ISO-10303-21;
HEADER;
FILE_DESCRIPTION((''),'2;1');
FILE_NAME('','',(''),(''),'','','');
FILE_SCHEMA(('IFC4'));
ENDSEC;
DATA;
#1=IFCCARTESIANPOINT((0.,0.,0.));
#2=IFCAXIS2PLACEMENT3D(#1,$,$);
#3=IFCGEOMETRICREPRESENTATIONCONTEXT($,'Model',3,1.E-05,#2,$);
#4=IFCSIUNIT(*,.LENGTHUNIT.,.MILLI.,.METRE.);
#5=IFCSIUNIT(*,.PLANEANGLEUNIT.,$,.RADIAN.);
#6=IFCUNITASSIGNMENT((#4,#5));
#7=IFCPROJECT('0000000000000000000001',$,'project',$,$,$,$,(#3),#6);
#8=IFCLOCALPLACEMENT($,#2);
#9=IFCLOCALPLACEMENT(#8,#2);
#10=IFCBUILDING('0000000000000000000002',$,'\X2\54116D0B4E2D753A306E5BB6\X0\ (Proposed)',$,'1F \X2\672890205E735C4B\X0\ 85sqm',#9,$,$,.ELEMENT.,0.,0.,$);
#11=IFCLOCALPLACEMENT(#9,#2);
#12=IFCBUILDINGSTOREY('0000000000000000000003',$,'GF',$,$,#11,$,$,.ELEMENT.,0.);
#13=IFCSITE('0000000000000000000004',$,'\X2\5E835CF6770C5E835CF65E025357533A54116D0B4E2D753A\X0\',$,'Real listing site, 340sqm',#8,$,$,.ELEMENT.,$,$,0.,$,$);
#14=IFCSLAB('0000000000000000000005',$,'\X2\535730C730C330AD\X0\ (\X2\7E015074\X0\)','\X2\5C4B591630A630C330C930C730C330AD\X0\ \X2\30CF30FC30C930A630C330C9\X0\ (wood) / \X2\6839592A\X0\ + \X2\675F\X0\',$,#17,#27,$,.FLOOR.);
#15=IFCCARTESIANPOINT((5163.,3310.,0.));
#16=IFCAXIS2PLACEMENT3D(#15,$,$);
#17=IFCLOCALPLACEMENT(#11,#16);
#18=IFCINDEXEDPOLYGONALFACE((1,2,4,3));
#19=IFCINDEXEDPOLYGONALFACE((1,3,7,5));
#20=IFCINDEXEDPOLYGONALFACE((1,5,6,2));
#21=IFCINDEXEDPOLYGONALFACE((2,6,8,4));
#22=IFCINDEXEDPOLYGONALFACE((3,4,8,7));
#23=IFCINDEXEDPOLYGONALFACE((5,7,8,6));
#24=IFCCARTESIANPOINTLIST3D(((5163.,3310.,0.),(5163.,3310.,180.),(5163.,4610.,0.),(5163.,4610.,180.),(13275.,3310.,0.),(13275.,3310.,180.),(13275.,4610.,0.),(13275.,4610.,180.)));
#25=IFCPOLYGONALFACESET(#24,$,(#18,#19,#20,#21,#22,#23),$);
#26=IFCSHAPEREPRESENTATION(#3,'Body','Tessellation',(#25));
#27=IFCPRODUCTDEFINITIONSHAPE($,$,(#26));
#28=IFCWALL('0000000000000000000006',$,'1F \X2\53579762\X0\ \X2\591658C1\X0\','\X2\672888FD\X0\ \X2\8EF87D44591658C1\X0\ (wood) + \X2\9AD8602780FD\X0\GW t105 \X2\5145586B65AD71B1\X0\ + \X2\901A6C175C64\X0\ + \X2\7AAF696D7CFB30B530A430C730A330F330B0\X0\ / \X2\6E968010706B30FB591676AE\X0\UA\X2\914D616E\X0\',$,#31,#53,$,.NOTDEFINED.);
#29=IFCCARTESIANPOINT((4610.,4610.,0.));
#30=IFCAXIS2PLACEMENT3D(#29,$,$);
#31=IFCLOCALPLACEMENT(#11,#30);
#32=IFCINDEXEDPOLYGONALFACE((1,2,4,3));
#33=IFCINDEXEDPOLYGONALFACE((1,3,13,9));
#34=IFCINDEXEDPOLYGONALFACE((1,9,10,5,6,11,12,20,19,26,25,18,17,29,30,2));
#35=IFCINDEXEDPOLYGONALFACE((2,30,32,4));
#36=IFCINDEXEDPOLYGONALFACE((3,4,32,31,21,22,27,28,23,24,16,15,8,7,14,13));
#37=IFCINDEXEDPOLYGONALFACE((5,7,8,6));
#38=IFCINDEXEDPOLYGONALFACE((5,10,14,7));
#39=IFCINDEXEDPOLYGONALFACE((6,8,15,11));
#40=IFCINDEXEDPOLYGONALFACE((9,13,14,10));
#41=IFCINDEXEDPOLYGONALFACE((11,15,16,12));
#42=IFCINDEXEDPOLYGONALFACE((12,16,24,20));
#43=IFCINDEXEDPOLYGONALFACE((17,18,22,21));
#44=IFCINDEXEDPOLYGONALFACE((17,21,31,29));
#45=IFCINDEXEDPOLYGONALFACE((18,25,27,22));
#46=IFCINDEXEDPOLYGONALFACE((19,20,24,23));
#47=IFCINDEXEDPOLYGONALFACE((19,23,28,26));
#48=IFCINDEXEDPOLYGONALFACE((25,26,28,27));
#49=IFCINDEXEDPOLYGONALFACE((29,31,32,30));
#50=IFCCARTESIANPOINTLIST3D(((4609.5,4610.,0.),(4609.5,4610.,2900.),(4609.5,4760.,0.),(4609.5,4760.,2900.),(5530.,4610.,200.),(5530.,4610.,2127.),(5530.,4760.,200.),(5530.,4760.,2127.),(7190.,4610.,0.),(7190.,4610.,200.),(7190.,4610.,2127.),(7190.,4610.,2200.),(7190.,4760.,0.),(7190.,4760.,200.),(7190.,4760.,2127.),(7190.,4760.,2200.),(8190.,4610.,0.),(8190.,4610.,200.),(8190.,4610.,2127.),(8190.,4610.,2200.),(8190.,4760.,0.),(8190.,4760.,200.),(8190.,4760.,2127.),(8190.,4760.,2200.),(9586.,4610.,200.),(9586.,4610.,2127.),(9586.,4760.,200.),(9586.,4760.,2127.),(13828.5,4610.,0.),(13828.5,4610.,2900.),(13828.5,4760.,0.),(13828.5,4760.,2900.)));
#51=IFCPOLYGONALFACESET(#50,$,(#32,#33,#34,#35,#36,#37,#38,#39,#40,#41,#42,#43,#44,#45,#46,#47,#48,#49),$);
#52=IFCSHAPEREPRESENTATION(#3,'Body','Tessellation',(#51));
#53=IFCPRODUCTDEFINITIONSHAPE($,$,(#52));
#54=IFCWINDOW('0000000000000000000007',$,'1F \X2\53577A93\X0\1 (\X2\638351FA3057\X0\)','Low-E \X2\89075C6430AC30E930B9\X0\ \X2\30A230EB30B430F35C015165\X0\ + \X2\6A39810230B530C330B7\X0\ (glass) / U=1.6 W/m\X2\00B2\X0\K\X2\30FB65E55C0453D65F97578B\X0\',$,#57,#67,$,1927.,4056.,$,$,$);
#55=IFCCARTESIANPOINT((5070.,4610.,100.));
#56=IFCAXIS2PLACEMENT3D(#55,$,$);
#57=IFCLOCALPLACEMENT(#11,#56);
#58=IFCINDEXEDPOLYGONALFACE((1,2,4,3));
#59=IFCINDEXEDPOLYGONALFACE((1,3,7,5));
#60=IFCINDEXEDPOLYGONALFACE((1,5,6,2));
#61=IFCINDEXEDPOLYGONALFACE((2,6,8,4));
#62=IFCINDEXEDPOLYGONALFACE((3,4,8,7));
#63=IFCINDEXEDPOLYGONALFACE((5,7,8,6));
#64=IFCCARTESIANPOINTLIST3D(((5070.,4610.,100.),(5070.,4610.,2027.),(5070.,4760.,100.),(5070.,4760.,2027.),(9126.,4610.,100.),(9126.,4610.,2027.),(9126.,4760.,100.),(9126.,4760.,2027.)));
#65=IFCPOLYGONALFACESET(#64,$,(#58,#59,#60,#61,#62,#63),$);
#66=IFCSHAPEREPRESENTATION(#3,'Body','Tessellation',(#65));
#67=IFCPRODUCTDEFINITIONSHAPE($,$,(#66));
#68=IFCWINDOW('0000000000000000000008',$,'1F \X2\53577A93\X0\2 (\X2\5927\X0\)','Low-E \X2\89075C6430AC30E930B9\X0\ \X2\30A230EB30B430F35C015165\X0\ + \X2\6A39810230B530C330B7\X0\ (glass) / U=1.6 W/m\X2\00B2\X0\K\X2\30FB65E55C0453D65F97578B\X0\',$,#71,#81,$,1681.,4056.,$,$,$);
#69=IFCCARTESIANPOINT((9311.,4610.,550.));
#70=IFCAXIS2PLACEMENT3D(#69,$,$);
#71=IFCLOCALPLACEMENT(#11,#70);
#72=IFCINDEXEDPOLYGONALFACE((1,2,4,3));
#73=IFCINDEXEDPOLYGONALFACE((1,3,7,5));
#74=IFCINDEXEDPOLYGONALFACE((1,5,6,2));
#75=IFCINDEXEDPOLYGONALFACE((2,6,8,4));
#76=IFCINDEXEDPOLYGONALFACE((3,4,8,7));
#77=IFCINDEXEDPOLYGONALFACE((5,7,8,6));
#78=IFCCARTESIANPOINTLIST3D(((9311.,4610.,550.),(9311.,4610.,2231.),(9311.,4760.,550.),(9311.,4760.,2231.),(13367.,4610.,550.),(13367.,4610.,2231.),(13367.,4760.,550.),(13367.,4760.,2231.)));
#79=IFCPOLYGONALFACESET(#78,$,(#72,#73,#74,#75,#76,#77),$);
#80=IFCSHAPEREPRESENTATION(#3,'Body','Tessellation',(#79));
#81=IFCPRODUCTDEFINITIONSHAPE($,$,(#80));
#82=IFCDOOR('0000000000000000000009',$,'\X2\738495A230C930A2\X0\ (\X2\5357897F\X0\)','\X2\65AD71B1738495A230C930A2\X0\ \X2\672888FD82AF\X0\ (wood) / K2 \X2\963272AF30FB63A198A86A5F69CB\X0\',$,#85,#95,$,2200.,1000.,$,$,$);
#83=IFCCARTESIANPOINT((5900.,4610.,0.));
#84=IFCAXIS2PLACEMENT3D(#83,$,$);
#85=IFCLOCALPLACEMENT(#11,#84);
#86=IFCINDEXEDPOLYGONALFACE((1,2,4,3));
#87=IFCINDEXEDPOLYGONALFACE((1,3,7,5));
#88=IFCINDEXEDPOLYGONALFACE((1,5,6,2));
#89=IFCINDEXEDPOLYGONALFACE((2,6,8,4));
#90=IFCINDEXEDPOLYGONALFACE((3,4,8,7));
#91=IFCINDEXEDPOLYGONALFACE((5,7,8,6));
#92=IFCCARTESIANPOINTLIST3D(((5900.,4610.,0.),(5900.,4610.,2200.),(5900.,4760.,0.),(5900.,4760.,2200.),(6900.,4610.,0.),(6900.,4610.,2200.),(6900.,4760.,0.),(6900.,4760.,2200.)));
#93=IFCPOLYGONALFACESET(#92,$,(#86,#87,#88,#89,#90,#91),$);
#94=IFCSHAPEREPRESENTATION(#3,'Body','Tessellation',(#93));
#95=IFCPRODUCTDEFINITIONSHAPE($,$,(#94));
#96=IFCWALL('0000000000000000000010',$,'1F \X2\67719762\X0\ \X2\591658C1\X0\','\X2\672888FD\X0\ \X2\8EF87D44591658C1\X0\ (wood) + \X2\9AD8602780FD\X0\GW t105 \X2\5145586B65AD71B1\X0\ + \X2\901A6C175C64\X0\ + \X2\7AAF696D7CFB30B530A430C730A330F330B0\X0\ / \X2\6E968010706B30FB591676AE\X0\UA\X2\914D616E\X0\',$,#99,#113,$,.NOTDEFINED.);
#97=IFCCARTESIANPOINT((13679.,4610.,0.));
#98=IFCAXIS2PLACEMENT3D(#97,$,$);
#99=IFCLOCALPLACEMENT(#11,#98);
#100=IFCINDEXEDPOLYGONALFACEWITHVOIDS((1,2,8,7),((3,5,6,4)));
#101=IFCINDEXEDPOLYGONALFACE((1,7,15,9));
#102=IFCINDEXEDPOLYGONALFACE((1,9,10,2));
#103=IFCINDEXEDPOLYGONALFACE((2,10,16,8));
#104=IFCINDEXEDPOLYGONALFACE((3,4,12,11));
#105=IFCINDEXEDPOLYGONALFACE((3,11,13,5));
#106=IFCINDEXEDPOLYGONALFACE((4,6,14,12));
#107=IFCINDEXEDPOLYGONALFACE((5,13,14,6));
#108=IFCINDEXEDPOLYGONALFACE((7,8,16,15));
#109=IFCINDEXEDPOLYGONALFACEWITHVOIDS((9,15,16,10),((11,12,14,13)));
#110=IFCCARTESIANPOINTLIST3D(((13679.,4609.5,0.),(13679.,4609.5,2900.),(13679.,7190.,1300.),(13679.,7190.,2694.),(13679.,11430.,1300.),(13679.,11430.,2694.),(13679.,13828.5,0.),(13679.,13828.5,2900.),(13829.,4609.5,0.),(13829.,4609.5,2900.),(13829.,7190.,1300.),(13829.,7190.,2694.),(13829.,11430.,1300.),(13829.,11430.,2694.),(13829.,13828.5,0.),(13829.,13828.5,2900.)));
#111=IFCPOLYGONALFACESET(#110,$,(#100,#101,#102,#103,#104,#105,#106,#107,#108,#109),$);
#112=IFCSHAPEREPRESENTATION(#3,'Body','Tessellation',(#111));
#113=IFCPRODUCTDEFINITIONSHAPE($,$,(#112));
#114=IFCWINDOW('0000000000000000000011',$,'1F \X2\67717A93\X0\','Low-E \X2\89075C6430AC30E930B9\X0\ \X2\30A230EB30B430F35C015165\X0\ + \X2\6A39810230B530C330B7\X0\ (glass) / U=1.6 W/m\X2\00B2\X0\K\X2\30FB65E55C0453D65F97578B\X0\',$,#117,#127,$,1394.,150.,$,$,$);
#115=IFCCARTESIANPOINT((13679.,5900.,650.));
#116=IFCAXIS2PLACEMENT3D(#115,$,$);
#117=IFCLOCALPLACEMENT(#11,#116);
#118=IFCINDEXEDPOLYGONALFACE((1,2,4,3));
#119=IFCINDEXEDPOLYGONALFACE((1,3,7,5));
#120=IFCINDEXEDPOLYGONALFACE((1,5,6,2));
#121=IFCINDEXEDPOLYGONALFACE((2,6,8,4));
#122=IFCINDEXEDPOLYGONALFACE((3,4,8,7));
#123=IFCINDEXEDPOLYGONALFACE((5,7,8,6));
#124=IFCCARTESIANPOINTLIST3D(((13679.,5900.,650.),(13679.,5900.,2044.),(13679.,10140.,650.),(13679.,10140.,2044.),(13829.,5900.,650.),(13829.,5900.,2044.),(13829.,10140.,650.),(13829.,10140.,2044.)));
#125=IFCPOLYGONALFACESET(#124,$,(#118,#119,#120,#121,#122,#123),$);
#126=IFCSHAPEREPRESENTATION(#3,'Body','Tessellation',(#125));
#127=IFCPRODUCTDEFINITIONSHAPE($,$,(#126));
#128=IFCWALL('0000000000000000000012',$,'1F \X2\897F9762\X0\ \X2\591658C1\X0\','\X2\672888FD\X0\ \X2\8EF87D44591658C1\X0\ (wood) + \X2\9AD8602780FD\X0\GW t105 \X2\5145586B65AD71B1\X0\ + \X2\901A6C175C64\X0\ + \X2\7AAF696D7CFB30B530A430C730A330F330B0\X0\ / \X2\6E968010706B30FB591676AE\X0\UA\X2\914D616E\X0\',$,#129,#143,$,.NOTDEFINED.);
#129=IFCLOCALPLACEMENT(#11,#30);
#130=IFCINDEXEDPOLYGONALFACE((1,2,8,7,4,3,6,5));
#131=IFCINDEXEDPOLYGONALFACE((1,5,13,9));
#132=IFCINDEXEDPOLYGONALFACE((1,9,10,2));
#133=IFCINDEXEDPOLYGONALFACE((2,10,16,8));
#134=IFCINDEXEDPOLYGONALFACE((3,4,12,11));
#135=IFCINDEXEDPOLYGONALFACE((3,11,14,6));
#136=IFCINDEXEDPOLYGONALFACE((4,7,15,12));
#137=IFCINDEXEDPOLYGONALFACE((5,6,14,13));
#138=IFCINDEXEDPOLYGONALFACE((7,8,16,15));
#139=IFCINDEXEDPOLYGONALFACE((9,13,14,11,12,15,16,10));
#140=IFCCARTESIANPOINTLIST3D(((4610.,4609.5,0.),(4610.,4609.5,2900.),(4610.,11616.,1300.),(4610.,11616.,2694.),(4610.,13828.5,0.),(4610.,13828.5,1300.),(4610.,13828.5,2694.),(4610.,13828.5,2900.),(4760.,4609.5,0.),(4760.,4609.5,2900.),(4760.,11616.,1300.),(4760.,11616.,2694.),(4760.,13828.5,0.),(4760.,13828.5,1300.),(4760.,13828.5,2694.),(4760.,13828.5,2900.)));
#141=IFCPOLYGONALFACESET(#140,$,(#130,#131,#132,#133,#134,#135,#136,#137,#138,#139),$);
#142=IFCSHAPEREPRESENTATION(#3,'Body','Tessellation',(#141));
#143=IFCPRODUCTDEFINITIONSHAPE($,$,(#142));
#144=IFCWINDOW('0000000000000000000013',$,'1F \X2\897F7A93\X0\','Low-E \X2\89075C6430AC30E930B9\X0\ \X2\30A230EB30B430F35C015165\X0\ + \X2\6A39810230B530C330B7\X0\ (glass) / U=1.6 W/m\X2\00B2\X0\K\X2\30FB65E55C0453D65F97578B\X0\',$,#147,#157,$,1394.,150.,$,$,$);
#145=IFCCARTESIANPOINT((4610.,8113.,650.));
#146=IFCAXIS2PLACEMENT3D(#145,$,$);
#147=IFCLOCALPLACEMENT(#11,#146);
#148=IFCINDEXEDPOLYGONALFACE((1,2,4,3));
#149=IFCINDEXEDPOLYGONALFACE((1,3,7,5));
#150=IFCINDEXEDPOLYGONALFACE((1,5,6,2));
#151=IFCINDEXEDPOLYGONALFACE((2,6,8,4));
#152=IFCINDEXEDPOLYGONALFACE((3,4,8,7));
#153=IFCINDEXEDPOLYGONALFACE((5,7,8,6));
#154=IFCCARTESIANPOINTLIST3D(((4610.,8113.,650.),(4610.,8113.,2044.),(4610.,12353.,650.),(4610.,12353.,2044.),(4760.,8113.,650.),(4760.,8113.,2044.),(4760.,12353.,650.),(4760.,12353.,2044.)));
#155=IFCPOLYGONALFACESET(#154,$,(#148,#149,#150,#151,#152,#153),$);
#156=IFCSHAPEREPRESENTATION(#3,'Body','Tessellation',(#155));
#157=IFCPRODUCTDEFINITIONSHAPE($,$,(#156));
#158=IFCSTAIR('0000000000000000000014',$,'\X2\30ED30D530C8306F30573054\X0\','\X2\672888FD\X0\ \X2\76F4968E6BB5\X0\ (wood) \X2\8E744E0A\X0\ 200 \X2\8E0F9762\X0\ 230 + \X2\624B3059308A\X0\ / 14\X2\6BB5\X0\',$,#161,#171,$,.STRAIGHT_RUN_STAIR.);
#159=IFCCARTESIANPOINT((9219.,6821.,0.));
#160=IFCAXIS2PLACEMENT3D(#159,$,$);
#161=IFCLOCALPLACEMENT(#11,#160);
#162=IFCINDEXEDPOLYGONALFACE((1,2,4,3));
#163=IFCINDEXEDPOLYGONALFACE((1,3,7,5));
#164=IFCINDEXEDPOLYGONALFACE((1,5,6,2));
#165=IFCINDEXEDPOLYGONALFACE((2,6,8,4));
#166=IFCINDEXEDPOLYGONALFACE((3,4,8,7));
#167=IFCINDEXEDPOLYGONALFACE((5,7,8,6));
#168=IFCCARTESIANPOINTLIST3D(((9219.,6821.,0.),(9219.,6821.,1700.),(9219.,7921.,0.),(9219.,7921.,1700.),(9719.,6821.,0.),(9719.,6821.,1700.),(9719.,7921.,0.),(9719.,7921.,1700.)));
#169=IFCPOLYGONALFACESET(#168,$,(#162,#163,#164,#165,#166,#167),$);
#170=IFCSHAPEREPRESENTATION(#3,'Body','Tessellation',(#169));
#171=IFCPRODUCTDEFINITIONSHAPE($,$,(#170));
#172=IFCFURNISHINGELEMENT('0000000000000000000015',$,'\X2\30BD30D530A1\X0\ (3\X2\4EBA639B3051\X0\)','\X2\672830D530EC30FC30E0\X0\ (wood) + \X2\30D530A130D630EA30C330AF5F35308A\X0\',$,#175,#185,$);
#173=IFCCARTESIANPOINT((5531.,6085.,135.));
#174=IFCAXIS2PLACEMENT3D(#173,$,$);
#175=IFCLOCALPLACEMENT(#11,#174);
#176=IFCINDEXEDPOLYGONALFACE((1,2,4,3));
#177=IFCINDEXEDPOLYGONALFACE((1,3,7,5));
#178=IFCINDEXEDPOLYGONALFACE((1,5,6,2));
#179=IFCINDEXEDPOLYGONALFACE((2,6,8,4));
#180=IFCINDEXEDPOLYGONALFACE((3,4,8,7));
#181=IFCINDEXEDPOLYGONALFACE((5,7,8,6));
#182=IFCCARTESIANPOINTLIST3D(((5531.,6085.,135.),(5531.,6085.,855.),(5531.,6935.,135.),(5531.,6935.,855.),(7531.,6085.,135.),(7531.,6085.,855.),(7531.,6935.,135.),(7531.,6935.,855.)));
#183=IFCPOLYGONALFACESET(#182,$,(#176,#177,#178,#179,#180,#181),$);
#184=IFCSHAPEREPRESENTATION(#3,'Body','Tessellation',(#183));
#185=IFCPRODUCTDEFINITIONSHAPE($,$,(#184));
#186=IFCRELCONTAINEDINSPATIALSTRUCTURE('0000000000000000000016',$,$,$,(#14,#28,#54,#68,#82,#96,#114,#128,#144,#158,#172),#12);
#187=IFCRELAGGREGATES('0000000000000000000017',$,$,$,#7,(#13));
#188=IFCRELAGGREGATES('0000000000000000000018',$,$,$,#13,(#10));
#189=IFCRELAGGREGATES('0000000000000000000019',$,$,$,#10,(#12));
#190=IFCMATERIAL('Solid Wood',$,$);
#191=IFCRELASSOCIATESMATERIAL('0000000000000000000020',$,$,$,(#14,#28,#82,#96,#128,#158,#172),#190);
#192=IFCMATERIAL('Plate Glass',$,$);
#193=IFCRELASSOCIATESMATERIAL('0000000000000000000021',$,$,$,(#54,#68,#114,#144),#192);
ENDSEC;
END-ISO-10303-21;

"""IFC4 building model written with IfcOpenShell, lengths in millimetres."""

from ifc_helpers import new_model, si_unit, frame, frame_2d, origin, place, context, project, spatial, rectangle, extrude, material, element, fill, save


model = new_model("IFC4")

# Units and contexts
model_context = context("Model", 3, precision=1e-05, world=origin())
ifc_project = project(units=[si_unit("LENGTHUNIT", "METRE", prefix="MILLI"), si_unit("PLANEANGLEUNIT", "RADIAN")], contexts=[model_context])

# Site, building, storey
site_placement = place(None, origin())
site = spatial("IfcSite", under=ifc_project, at=site_placement, Name="広島県広島市南区向洋中町", ObjectType="Real listing site, 340sqm", CompositionType="ELEMENT", RefElevation=0.0)
building_placement = place(site_placement, origin())
building = spatial("IfcBuilding", under=site, at=building_placement, Name="向洋中町の家 (Proposed)", ObjectType="1F 木造平屋 85sqm", CompositionType="ELEMENT", ElevationOfRefHeight=0.0, ElevationOfTerrain=0.0)
storey_placement = place(building_placement, origin())
storey = spatial("IfcBuildingStorey", under=building, at=storey_placement, Name="GF", CompositionType="ELEMENT", Elevation=0.0)

# Slab
ifc_material_1 = material(Name="Solid Wood")
slab_1_placement = place(storey_placement, frame((5163.0, 3310.0, 0.0)))
element("IfcSlab", 1, at=slab_1_placement, inside=storey, material=ifc_material_1, Name="南デッキ (縁側)", Description="屋外ウッドデッキ ハードウッド (wood) / 根太 + 束", PredefinedType="FLOOR", context=model_context, shape_type="SweptSolid", body=[
    extrude(rectangle(XDim=8112.0, YDim=1300.0, at=frame_2d((4056.0, 650.0))), frame((5163.0, 3310.0, 0.0)), (0.0, 0.0, 1.0), 180.0),
])

# Wall, openings, windows, door
wall_1_placement = place(storey_placement, frame((4610.0, 4610.0, 0.0)))
wall_1 = element("IfcWall", 2, at=wall_1_placement, inside=storey, material=ifc_material_1, Name="1F 南面 外壁", Description="木製 軸組外壁 (wood) + 高性能GW t105 充填断熱 + 通気層 + 窯業系サイディング / 準耐火・外皮UA配慮", PredefinedType="NOTDEFINED", context=model_context, shape_type="SweptSolid", body=[
    extrude(rectangle(XDim=9219.0, YDim=150.0, at=frame_2d((4609.0, 75.0))), frame((4610.0, 4610.0, 0.0)), (0.0, 0.0, 1.0), 2900.0),
])
opening_1_placement = place(storey_placement, frame((5070.0, 4610.0, 100.0)))
opening_1 = element("IfcOpeningElement", 3, at=opening_1_placement, cuts=wall_1, PredefinedType="NOTDEFINED", context=model_context, shape_type="SweptSolid", body=[
    extrude(rectangle(XDim=4056.0, YDim=150.0, at=frame_2d((2028.0, 75.0))), frame((5070.0, 4610.0, 100.0)), (0.0, 0.0, 1.0), 1927.0),
])
opening_2_placement = place(storey_placement, frame((9311.0, 4610.0, 550.0)))
opening_2 = element("IfcOpeningElement", 4, at=opening_2_placement, cuts=wall_1, PredefinedType="NOTDEFINED", context=model_context, shape_type="SweptSolid", body=[
    extrude(rectangle(XDim=4056.0, YDim=150.0, at=frame_2d((2028.0, 75.0))), frame((9311.0, 4610.0, 550.0)), (0.0, 0.0, 1.0), 1681.0),
])
opening_3_placement = place(storey_placement, frame((5900.0, 4610.0, 0.0)))
opening_3 = element("IfcOpeningElement", 5, at=opening_3_placement, cuts=wall_1, PredefinedType="NOTDEFINED", context=model_context, shape_type="SweptSolid", body=[
    extrude(rectangle(XDim=1000.0, YDim=150.0, at=frame_2d((500.0, 75.0))), frame((5900.0, 4610.0, 0.0)), (0.0, 0.0, 1.0), 2200.0),
])
ifc_material_2 = material(Name="Plate Glass")
window_1_placement = place(storey_placement, frame((5070.0, 4610.0, 100.0)))
window_1 = element("IfcWindow", 6, at=window_1_placement, inside=storey, material=ifc_material_2, Name="1F 南窓1 (掃出し)", Description="Low-E 複層ガラス アルゴン封入 + 樹脂サッシ (glass) / U=1.6 W/m²K・日射取得型", OverallHeight=1927.0, OverallWidth=4056.0, context=model_context, shape_type="SweptSolid", body=[
    extrude(rectangle(XDim=4056.0, YDim=150.0, at=frame_2d((2028.0, 75.0))), frame((5070.0, 4610.0, 100.0)), (0.0, 0.0, 1.0), 1927.0),
])
fill(opening_1, window_1)
window_2_placement = place(storey_placement, frame((9311.0, 4610.0, 550.0)))
window_2 = element("IfcWindow", 7, at=window_2_placement, inside=storey, material=ifc_material_2, Name="1F 南窓2 (大)", Description="Low-E 複層ガラス アルゴン封入 + 樹脂サッシ (glass) / U=1.6 W/m²K・日射取得型", OverallHeight=1681.0, OverallWidth=4056.0, context=model_context, shape_type="SweptSolid", body=[
    extrude(rectangle(XDim=4056.0, YDim=150.0, at=frame_2d((2028.0, 75.0))), frame((9311.0, 4610.0, 550.0)), (0.0, 0.0, 1.0), 1681.0),
])
fill(opening_2, window_2)
door_placement = place(storey_placement, frame((5900.0, 4610.0, 0.0)))
door = element("IfcDoor", 8, at=door_placement, inside=storey, material=ifc_material_1, Name="玄関ドア (南西)", Description="断熱玄関ドア 木製芯 (wood) / K2 防犯・採風機構", OverallHeight=2200.0, OverallWidth=1000.0, context=model_context, shape_type="SweptSolid", body=[
    extrude(rectangle(XDim=1000.0, YDim=150.0, at=frame_2d((500.0, 75.0))), frame((5900.0, 4610.0, 0.0)), (0.0, 0.0, 1.0), 2200.0),
])
fill(opening_3, door)

# Walls, openings, windows
wall_2_placement = place(storey_placement, frame((13679.0, 4610.0, 0.0)))
wall_2 = element("IfcWall", 9, at=wall_2_placement, inside=storey, material=ifc_material_1, Name="1F 東面 外壁", Description="木製 軸組外壁 (wood) + 高性能GW t105 充填断熱 + 通気層 + 窯業系サイディング / 準耐火・外皮UA配慮", PredefinedType="NOTDEFINED", context=model_context, shape_type="SweptSolid", body=[
    extrude(rectangle(XDim=150.0, YDim=9219.0, at=frame_2d((75.0, 4609.0))), frame((13679.0, 4610.0, 0.0)), (0.0, 0.0, 1.0), 2900.0),
])
opening_4_placement = place(storey_placement, frame((13679.0, 5900.0, 650.0)))
opening_4 = element("IfcOpeningElement", 10, at=opening_4_placement, cuts=wall_2, PredefinedType="NOTDEFINED", context=model_context, shape_type="SweptSolid", body=[
    extrude(rectangle(XDim=150.0, YDim=4240.0, at=frame_2d((75.0, 2120.0))), frame((13679.0, 5900.0, 650.0)), (0.0, 0.0, 1.0), 1394.0),
])
window_3_placement = place(storey_placement, frame((13679.0, 5900.0, 650.0)))
window_3 = element("IfcWindow", 11, at=window_3_placement, inside=storey, material=ifc_material_2, Name="1F 東窓", Description="Low-E 複層ガラス アルゴン封入 + 樹脂サッシ (glass) / U=1.6 W/m²K・日射取得型", OverallHeight=1394.0, OverallWidth=150.0, context=model_context, shape_type="SweptSolid", body=[
    extrude(rectangle(XDim=150.0, YDim=4240.0, at=frame_2d((75.0, 2120.0))), frame((13679.0, 5900.0, 650.0)), (0.0, 0.0, 1.0), 1394.0),
])
fill(opening_4, window_3)
wall_3_placement = place(storey_placement, frame((4610.0, 4610.0, 0.0)))
wall_3 = element("IfcWall", 12, at=wall_3_placement, inside=storey, material=ifc_material_1, Name="1F 西面 外壁", Description="木製 軸組外壁 (wood) + 高性能GW t105 充填断熱 + 通気層 + 窯業系サイディング / 準耐火・外皮UA配慮", PredefinedType="NOTDEFINED", context=model_context, shape_type="SweptSolid", body=[
    extrude(rectangle(XDim=150.0, YDim=9219.0, at=frame_2d((75.0, 4609.0))), frame((4610.0, 4610.0, 0.0)), (0.0, 0.0, 1.0), 2900.0),
])
opening_5_placement = place(storey_placement, frame((4610.0, 8113.0, 650.0)))
opening_5 = element("IfcOpeningElement", 13, at=opening_5_placement, cuts=wall_3, PredefinedType="NOTDEFINED", context=model_context, shape_type="SweptSolid", body=[
    extrude(rectangle(XDim=150.0, YDim=4240.0, at=frame_2d((75.0, 2120.0))), frame((4610.0, 8113.0, 650.0)), (0.0, 0.0, 1.0), 1394.0),
])
window_4_placement = place(storey_placement, frame((4610.0, 8113.0, 650.0)))
window_4 = element("IfcWindow", 14, at=window_4_placement, inside=storey, material=ifc_material_2, Name="1F 西窓", Description="Low-E 複層ガラス アルゴン封入 + 樹脂サッシ (glass) / U=1.6 W/m²K・日射取得型", OverallHeight=1394.0, OverallWidth=150.0, context=model_context, shape_type="SweptSolid", body=[
    extrude(rectangle(XDim=150.0, YDim=4240.0, at=frame_2d((75.0, 2120.0))), frame((4610.0, 8113.0, 650.0)), (0.0, 0.0, 1.0), 1394.0),
])
fill(opening_5, window_4)

# Stair
stair_placement = place(storey_placement, frame((9219.0, 6821.0, 0.0)))
element("IfcStair", 15, at=stair_placement, inside=storey, material=ifc_material_1, Name="ロフトはしご", Description="木製 直階段 (wood) 蹴上 200 踏面 230 + 手すり / 14段", PredefinedType="STRAIGHT_RUN_STAIR", context=model_context, shape_type="SweptSolid", body=[
    extrude(rectangle(XDim=500.0, YDim=1100.0, at=frame_2d((250.0, 550.0))), frame((9219.0, 6821.0, 0.0)), (0.0, 0.0, 1.0), 1700.0),
])

# Furnishing element
furnishing_1_placement = place(storey_placement, frame((5531.0, 6085.0, 135.0)))
element("IfcFurnishingElement", 16, at=furnishing_1_placement, inside=storey, material=ifc_material_1, Name="ソファ (3人掛け)", Description="木フレーム (wood) + ファブリック張り", context=model_context, shape_type="SweptSolid", body=[
    extrude(rectangle(XDim=2000.0, YDim=850.0, at=frame_2d((1000.0, 425.0))), frame((5531.0, 6085.0, 135.0)), (0.0, 0.0, 1.0), 720.0),
])

save(model, "model.ifc")
